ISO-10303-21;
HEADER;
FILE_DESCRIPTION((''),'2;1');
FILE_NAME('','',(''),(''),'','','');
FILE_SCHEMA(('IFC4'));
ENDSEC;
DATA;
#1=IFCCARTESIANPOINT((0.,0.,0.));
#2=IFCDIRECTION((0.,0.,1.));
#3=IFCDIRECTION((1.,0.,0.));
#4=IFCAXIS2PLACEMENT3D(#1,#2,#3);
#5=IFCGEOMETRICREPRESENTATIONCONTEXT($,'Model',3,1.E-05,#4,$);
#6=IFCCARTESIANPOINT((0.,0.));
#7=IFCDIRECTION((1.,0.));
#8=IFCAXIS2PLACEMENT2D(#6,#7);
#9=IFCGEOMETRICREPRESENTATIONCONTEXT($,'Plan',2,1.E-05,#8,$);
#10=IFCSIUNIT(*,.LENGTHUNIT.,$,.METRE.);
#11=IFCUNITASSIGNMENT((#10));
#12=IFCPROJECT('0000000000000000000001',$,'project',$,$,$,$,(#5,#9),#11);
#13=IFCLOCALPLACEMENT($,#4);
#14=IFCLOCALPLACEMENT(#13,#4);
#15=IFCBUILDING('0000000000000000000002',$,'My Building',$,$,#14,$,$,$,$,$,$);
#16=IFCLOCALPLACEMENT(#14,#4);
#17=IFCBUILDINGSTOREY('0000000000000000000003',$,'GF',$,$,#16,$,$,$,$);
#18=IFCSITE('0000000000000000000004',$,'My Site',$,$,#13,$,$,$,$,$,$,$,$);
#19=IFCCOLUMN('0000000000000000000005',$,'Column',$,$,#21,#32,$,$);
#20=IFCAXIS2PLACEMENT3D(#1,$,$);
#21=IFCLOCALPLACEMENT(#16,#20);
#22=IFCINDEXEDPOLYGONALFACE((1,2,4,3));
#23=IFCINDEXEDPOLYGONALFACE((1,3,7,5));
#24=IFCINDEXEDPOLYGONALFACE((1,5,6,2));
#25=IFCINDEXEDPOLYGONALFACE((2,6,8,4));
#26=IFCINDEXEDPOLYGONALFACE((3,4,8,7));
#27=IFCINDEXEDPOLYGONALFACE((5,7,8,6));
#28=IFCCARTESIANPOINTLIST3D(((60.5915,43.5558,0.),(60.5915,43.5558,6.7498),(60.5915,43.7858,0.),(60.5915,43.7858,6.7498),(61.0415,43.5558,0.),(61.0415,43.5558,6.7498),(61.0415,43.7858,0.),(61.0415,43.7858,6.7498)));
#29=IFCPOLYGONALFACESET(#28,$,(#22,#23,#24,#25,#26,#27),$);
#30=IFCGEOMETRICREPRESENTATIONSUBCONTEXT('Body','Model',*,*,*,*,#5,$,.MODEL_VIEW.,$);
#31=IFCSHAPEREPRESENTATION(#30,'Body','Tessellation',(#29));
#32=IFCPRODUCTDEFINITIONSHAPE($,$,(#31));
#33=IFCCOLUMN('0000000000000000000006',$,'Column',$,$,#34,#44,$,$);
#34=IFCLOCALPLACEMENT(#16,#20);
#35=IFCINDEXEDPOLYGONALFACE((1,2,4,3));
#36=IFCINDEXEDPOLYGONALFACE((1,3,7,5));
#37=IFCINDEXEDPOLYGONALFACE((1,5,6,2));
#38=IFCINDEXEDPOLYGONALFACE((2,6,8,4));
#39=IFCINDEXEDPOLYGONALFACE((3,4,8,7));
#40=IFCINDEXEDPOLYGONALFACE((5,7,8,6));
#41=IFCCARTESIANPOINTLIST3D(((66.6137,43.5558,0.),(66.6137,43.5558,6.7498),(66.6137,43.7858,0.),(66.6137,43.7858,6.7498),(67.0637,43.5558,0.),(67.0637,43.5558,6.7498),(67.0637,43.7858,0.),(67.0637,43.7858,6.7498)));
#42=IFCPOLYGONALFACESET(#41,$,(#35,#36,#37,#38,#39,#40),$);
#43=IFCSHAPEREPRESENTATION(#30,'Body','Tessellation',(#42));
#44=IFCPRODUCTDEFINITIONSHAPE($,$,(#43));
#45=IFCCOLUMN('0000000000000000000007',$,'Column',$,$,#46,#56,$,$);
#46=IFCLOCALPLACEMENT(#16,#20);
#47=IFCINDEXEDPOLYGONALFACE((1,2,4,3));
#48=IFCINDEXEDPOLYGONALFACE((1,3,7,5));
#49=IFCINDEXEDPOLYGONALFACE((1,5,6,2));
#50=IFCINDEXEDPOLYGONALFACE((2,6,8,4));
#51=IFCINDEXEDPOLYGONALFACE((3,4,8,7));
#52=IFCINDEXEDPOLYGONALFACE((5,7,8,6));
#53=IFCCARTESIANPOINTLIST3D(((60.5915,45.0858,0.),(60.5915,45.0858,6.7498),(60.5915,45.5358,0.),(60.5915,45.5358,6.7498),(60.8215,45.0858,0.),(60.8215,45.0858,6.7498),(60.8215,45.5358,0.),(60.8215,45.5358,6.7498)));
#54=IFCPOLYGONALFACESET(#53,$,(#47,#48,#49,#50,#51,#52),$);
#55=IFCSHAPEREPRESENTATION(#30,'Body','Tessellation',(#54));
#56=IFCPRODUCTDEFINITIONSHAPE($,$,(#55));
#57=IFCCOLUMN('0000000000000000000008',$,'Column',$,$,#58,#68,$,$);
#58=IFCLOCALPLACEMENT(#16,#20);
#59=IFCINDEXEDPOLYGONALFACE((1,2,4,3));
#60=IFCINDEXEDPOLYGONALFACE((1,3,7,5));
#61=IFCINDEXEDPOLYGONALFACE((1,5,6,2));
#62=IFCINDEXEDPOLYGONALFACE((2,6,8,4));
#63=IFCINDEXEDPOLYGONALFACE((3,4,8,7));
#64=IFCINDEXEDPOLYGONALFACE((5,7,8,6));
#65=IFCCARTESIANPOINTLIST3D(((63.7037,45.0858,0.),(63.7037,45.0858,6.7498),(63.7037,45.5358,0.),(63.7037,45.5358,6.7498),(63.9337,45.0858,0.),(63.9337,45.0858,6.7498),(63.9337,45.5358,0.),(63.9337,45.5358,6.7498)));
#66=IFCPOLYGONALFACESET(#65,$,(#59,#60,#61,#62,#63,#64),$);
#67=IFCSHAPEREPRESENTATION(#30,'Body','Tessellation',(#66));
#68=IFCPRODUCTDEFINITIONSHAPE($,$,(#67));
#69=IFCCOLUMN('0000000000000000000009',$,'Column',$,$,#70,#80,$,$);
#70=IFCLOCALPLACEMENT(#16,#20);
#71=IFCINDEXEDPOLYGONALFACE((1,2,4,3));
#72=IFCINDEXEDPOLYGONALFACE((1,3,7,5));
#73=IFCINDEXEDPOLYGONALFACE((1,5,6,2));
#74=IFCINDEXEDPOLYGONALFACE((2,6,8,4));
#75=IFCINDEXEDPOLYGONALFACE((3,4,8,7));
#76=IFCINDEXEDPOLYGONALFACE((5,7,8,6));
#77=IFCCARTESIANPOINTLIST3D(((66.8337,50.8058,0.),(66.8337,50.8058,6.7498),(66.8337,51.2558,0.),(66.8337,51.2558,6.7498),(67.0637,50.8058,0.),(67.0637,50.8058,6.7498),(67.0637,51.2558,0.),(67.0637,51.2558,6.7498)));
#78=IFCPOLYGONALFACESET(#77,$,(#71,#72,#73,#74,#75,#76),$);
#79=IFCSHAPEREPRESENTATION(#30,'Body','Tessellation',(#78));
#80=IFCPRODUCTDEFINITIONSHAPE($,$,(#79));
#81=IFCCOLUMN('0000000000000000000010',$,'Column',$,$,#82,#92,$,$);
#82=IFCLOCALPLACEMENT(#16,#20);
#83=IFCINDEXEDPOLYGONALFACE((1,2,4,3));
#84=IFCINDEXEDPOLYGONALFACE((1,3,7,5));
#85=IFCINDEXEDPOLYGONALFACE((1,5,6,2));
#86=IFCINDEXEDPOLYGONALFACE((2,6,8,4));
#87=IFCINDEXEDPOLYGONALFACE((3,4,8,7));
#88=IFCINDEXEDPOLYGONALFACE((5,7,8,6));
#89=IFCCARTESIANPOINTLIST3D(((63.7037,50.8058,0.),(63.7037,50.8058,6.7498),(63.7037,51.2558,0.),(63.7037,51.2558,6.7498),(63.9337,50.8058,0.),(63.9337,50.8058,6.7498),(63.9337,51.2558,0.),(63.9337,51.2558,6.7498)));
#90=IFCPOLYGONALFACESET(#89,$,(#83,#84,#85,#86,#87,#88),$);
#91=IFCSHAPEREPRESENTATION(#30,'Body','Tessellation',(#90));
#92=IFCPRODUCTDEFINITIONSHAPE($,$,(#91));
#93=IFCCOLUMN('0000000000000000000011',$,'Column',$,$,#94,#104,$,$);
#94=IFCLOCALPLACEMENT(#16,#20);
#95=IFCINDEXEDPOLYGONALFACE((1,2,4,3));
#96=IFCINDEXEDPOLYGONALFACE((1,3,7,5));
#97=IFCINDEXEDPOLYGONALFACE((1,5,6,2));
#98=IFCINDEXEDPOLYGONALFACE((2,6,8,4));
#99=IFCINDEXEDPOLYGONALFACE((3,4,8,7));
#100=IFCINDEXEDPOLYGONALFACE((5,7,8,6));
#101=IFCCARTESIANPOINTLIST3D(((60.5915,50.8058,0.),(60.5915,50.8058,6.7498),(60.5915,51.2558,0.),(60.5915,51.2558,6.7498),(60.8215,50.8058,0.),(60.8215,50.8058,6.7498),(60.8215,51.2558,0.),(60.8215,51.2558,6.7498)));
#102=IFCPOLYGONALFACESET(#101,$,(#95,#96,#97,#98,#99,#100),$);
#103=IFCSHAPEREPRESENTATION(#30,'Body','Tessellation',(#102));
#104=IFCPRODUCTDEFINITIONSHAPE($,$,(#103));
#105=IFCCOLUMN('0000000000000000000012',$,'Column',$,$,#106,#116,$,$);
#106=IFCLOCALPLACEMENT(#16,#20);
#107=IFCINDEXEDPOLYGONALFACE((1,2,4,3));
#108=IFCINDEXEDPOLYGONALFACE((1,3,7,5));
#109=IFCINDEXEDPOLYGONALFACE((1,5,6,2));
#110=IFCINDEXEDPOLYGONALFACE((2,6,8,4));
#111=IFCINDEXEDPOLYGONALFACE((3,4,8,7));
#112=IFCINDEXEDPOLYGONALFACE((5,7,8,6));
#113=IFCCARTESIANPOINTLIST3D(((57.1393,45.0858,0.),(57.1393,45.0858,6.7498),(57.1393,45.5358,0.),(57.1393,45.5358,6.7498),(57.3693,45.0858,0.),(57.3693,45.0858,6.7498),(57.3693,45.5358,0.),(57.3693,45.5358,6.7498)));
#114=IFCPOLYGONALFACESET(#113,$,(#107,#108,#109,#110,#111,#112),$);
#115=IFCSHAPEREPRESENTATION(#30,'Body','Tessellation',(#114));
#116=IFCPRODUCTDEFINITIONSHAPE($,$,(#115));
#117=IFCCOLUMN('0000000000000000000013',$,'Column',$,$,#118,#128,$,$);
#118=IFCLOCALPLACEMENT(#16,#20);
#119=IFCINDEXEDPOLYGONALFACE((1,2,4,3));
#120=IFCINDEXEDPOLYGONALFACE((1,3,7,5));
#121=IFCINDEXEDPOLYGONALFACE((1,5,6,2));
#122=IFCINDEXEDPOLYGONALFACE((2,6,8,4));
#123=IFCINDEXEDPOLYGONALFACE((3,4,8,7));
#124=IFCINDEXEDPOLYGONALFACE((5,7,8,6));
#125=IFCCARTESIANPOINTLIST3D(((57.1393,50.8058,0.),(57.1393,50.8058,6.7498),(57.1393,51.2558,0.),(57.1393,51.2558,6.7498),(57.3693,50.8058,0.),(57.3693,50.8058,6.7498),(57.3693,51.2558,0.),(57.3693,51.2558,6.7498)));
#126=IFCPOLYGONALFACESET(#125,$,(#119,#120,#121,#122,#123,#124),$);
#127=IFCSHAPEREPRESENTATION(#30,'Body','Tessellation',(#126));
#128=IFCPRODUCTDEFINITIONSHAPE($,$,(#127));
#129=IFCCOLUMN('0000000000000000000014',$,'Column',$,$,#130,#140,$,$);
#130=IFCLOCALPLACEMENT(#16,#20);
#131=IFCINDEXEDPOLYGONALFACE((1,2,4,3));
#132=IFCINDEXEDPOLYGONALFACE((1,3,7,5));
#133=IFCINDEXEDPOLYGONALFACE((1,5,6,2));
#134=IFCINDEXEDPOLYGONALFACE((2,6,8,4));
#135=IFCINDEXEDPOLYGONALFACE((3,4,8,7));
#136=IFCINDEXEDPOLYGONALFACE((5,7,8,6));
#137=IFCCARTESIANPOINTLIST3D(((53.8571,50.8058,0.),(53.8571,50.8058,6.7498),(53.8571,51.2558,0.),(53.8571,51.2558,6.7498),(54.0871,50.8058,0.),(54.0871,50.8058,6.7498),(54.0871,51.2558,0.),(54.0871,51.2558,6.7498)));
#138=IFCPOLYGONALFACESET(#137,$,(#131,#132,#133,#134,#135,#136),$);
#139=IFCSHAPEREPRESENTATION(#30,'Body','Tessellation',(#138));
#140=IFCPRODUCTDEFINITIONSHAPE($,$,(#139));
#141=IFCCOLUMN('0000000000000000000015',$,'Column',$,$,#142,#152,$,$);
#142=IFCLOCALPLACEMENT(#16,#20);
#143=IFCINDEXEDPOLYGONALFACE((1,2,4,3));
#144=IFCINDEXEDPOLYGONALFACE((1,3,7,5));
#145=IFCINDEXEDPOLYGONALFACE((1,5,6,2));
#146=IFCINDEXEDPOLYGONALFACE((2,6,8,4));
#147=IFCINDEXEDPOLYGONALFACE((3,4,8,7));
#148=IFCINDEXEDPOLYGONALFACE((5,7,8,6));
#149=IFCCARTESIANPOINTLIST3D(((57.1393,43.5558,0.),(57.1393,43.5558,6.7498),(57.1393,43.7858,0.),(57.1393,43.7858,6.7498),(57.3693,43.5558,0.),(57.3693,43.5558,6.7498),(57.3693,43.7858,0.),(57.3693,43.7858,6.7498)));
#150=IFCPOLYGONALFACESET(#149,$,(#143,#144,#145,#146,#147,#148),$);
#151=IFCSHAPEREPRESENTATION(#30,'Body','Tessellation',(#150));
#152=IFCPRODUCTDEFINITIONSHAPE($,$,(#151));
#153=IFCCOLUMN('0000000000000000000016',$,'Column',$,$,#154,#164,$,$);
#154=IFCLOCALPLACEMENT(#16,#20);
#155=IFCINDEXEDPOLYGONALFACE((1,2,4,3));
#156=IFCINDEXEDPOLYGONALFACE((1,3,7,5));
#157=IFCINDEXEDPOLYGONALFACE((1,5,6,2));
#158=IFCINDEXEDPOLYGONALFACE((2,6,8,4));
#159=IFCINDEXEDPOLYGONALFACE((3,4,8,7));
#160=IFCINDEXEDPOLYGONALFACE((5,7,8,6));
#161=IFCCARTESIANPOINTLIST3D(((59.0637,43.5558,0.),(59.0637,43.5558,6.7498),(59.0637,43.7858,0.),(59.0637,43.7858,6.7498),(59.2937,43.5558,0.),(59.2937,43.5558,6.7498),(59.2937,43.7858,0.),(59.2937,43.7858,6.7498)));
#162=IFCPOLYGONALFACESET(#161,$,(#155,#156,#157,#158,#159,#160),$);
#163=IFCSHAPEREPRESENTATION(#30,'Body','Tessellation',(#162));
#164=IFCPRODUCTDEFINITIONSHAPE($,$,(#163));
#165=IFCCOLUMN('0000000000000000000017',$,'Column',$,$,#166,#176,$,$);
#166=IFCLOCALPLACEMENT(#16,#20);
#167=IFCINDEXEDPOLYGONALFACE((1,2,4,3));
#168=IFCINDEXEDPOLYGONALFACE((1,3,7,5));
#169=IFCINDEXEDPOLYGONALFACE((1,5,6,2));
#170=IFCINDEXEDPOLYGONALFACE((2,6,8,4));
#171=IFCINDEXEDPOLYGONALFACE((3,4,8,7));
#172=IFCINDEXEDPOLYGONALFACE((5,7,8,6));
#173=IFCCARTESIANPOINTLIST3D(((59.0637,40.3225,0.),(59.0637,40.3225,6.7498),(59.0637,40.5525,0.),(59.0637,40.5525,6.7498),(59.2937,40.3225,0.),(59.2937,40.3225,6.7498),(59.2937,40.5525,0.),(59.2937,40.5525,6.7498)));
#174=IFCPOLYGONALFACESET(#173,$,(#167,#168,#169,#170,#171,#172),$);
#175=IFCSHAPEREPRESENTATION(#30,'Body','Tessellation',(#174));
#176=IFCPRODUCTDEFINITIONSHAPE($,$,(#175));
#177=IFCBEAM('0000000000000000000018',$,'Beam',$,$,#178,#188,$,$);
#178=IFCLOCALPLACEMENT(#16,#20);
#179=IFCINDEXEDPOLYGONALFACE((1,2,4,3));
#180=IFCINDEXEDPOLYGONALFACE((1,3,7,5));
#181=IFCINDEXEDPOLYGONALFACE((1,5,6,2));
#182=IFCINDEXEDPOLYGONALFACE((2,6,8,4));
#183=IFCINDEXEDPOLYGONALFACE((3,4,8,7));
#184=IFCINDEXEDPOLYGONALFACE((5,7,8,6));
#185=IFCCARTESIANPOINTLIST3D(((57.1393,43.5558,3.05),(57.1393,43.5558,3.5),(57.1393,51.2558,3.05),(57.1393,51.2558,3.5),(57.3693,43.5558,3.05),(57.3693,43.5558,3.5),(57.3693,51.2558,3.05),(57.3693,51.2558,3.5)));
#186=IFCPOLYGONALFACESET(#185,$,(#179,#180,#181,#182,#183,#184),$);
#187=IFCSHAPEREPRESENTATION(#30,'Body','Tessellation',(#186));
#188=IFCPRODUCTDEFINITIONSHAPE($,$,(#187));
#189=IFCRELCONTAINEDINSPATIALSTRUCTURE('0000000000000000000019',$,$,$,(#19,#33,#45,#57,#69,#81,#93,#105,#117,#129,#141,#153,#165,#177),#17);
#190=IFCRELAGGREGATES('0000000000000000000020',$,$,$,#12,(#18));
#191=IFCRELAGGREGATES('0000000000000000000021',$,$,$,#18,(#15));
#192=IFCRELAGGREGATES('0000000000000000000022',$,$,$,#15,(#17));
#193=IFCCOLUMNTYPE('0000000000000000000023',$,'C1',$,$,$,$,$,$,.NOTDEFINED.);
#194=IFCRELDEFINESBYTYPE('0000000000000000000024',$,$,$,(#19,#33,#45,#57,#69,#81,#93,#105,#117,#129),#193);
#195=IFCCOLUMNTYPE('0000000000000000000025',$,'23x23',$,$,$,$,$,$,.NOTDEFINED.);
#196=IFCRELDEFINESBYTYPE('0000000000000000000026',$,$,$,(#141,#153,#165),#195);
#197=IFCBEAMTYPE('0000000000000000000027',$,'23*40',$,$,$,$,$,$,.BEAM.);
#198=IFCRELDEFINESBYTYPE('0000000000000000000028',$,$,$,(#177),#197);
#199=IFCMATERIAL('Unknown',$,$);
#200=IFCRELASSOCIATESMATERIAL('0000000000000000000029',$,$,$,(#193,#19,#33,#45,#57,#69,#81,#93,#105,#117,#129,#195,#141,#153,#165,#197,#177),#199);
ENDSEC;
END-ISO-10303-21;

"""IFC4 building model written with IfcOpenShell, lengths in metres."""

from ifc_helpers import new_model, si_unit, frame, origin_with_axes, origin_2d_with_axis, place, context, subcontext, project, spatial, rectangle, extrude, material, material_profile, profile_set, profile_usage, type_object, element, save


model = new_model("IFC4")

# Units and contexts
model_context = context("Model", 3, precision=1e-05, world=origin_with_axes())
plan_context = context("Plan", 2, precision=1e-05, world=origin_2d_with_axis())
body_context = subcontext(model_context, "Body", "Model", "MODEL_VIEW")
ifc_project = project(units=[si_unit("LENGTHUNIT", "METRE")], contexts=[model_context, plan_context])

# Site, building, storey
site_placement = place(None, origin_with_axes())
site = spatial("IfcSite", under=ifc_project, at=site_placement, Name="My Site")
building_placement = place(site_placement, origin_with_axes())
building = spatial("IfcBuilding", under=site, at=building_placement, Name="My Building")
storey_placement = place(building_placement, origin_with_axes())
storey = spatial("IfcBuildingStorey", under=building, at=storey_placement, Name="GF")

# Columns
ifc_material = material(Name="Unknown")
ifc_material_profile_1 = material_profile(ifc_material, rectangle(XDim=0.45, YDim=0.23))
ifc_profile_set_1 = profile_set([ifc_material_profile_1])
ifc_profile_usage_1 = profile_usage(ifc_profile_set_1, cardinal=5)
column_type_1 = type_object("IfcColumnType", Name="C1", PredefinedType="NOTDEFINED", material=ifc_profile_set_1)
column_1_placement = place(storey_placement, frame((60.8165, 43.6708, 0.0), z_axis=(0.0, 0.0, 1.0), x_axis=(1.0, 0.0, 0.0)))
element("IfcColumn", 1, at=column_1_placement, inside=storey, type_object=column_type_1, material=ifc_profile_usage_1, Name="Column", context=body_context, shape_type="SweptSolid", body=[
    extrude(rectangle(XDim=0.45, YDim=0.23), origin_with_axes(), (0.0, 0.0, 1.0), 6.7498),
])
ifc_profile_usage_2 = profile_usage(ifc_profile_set_1, cardinal=5)
column_2_placement = place(storey_placement, frame((66.8387, 43.6708, 0.0), z_axis=(0.0, 0.0, 1.0), x_axis=(1.0, 0.0, 0.0)))
element("IfcColumn", 2, at=column_2_placement, inside=storey, type_object=column_type_1, material=ifc_profile_usage_2, Name="Column", context=body_context, shape_type="SweptSolid", body=[
    extrude(rectangle(XDim=0.45, YDim=0.23), origin_with_axes(), (0.0, 0.0, 1.0), 6.7498),
])
ifc_profile_usage_3 = profile_usage(ifc_profile_set_1, cardinal=5)
column_3_placement = place(storey_placement, frame((60.7065, 45.3108, 0.0), z_axis=(0.0, 0.0, 1.0), x_axis=(0.0, 1.0, 0.0)))
element("IfcColumn", 3, at=column_3_placement, inside=storey, type_object=column_type_1, material=ifc_profile_usage_3, Name="Column", context=body_context, shape_type="SweptSolid", body=[
    extrude(rectangle(XDim=0.45, YDim=0.23), origin_with_axes(), (0.0, 0.0, 1.0), 6.7498),
])
ifc_profile_usage_4 = profile_usage(ifc_profile_set_1, cardinal=5)
column_4_placement = place(storey_placement, frame((63.8187, 45.3108, 0.0), z_axis=(0.0, 0.0, 1.0), x_axis=(0.0, 1.0, 0.0)))
element("IfcColumn", 4, at=column_4_placement, inside=storey, type_object=column_type_1, material=ifc_profile_usage_4, Name="Column", context=body_context, shape_type="SweptSolid", body=[
    extrude(rectangle(XDim=0.45, YDim=0.23), origin_with_axes(), (0.0, 0.0, 1.0), 6.7498),
])
ifc_profile_usage_5 = profile_usage(ifc_profile_set_1, cardinal=5)
column_5_placement = place(storey_placement, frame((66.9487, 51.0308, 0.0), z_axis=(0.0, 0.0, 1.0), x_axis=(0.0, 1.0, 0.0)))
element("IfcColumn", 5, at=column_5_placement, inside=storey, type_object=column_type_1, material=ifc_profile_usage_5, Name="Column", context=body_context, shape_type="SweptSolid", body=[
    extrude(rectangle(XDim=0.45, YDim=0.23), origin_with_axes(), (0.0, 0.0, 1.0), 6.7498),
])
ifc_profile_usage_6 = profile_usage(ifc_profile_set_1, cardinal=5)
column_6_placement = place(storey_placement, frame((63.8187, 51.0308, 0.0), z_axis=(0.0, 0.0, 1.0), x_axis=(0.0, 1.0, 0.0)))
element("IfcColumn", 6, at=column_6_placement, inside=storey, type_object=column_type_1, material=ifc_profile_usage_6, Name="Column", context=body_context, shape_type="SweptSolid", body=[
    extrude(rectangle(XDim=0.45, YDim=0.23), origin_with_axes(), (0.0, 0.0, 1.0), 6.7498),
])
ifc_profile_usage_7 = profile_usage(ifc_profile_set_1, cardinal=5)
column_7_placement = place(storey_placement, frame((60.7065, 51.0308, 0.0), z_axis=(0.0, 0.0, 1.0), x_axis=(0.0, 1.0, 0.0)))
element("IfcColumn", 7, at=column_7_placement, inside=storey, type_object=column_type_1, material=ifc_profile_usage_7, Name="Column", context=body_context, shape_type="SweptSolid", body=[
    extrude(rectangle(XDim=0.45, YDim=0.23), origin_with_axes(), (0.0, 0.0, 1.0), 6.7498),
])
ifc_profile_usage_8 = profile_usage(ifc_profile_set_1, cardinal=5)
column_8_placement = place(storey_placement, frame((57.2543, 45.3108, 0.0), z_axis=(0.0, 0.0, 1.0), x_axis=(0.0, 1.0, 0.0)))
element("IfcColumn", 8, at=column_8_placement, inside=storey, type_object=column_type_1, material=ifc_profile_usage_8, Name="Column", context=body_context, shape_type="SweptSolid", body=[
    extrude(rectangle(XDim=0.45, YDim=0.23), origin_with_axes(), (0.0, 0.0, 1.0), 6.7498),
])
ifc_profile_usage_9 = profile_usage(ifc_profile_set_1, cardinal=5)
column_9_placement = place(storey_placement, frame((57.2543, 51.0308, 0.0), z_axis=(0.0, 0.0, 1.0), x_axis=(0.0, 1.0, 0.0)))
element("IfcColumn", 9, at=column_9_placement, inside=storey, type_object=column_type_1, material=ifc_profile_usage_9, Name="Column", context=body_context, shape_type="SweptSolid", body=[
    extrude(rectangle(XDim=0.45, YDim=0.23), origin_with_axes(), (0.0, 0.0, 1.0), 6.7498),
])
ifc_profile_usage_10 = profile_usage(ifc_profile_set_1, cardinal=5)
column_10_placement = place(storey_placement, frame((53.9721, 51.0308, 0.0), z_axis=(0.0, 0.0, 1.0), x_axis=(0.0, 1.0, 0.0)))
element("IfcColumn", 10, at=column_10_placement, inside=storey, type_object=column_type_1, material=ifc_profile_usage_10, Name="Column", context=body_context, shape_type="SweptSolid", body=[
    extrude(rectangle(XDim=0.45, YDim=0.23), origin_with_axes(), (0.0, 0.0, 1.0), 6.7498),
])
ifc_material_profile_2 = material_profile(ifc_material, rectangle(XDim=0.23, YDim=0.23))
ifc_profile_set_2 = profile_set([ifc_material_profile_2])
ifc_profile_usage_11 = profile_usage(ifc_profile_set_2, cardinal=5)
column_type_2 = type_object("IfcColumnType", Name="23x23", PredefinedType="NOTDEFINED", material=ifc_profile_set_2)
column_11_placement = place(storey_placement, frame((57.2543, 43.6708, 0.0), z_axis=(0.0, 0.0, 1.0), x_axis=(1.0, 0.0, 0.0)))
element("IfcColumn", 11, at=column_11_placement, inside=storey, type_object=column_type_2, material=ifc_profile_usage_11, Name="Column", context=body_context, shape_type="SweptSolid", body=[
    extrude(rectangle(XDim=0.23, YDim=0.23), origin_with_axes(), (0.0, 0.0, 1.0), 6.7498),
])
ifc_profile_usage_12 = profile_usage(ifc_profile_set_2, cardinal=5)
column_12_placement = place(storey_placement, frame((59.1787, 43.6708, 0.0), z_axis=(0.0, 0.0, 1.0), x_axis=(1.0, 0.0, 0.0)))
element("IfcColumn", 12, at=column_12_placement, inside=storey, type_object=column_type_2, material=ifc_profile_usage_12, Name="Column", context=body_context, shape_type="SweptSolid", body=[
    extrude(rectangle(XDim=0.23, YDim=0.23), origin_with_axes(), (0.0, 0.0, 1.0), 6.7498),
])
ifc_profile_usage_13 = profile_usage(ifc_profile_set_2, cardinal=5)
column_13_placement = place(storey_placement, frame((59.1787, 40.4375, 0.0), z_axis=(0.0, 0.0, 1.0), x_axis=(1.0, 0.0, 0.0)))
element("IfcColumn", 13, at=column_13_placement, inside=storey, type_object=column_type_2, material=ifc_profile_usage_13, Name="Column", context=body_context, shape_type="SweptSolid", body=[
    extrude(rectangle(XDim=0.23, YDim=0.23), origin_with_axes(), (0.0, 0.0, 1.0), 6.7498),
])

# Beam
ifc_material_profile_3 = material_profile(ifc_material, rectangle(XDim=0.23, YDim=0.45))
ifc_profile_set_3 = profile_set([ifc_material_profile_3])
ifc_profile_usage_14 = profile_usage(ifc_profile_set_3, cardinal=5)
beam_type = type_object("IfcBeamType", Name="23*40", PredefinedType="BEAM", material=ifc_profile_set_3)
beam_1_placement = place(storey_placement, frame((57.2543, 43.5558, 3.275), z_axis=(0.0, 1.0, 0.0), x_axis=(-1.0, 0.0, 0.0)))
element("IfcBeam", 14, at=beam_1_placement, inside=storey, type_object=beam_type, material=ifc_profile_usage_14, Name="Beam", context=body_context, shape_type="SweptSolid", body=[
    extrude(rectangle(XDim=0.23, YDim=0.45), origin_with_axes(), (0.0, 0.0, 1.0), 7.7),
])

save(model, "model.ifc")
